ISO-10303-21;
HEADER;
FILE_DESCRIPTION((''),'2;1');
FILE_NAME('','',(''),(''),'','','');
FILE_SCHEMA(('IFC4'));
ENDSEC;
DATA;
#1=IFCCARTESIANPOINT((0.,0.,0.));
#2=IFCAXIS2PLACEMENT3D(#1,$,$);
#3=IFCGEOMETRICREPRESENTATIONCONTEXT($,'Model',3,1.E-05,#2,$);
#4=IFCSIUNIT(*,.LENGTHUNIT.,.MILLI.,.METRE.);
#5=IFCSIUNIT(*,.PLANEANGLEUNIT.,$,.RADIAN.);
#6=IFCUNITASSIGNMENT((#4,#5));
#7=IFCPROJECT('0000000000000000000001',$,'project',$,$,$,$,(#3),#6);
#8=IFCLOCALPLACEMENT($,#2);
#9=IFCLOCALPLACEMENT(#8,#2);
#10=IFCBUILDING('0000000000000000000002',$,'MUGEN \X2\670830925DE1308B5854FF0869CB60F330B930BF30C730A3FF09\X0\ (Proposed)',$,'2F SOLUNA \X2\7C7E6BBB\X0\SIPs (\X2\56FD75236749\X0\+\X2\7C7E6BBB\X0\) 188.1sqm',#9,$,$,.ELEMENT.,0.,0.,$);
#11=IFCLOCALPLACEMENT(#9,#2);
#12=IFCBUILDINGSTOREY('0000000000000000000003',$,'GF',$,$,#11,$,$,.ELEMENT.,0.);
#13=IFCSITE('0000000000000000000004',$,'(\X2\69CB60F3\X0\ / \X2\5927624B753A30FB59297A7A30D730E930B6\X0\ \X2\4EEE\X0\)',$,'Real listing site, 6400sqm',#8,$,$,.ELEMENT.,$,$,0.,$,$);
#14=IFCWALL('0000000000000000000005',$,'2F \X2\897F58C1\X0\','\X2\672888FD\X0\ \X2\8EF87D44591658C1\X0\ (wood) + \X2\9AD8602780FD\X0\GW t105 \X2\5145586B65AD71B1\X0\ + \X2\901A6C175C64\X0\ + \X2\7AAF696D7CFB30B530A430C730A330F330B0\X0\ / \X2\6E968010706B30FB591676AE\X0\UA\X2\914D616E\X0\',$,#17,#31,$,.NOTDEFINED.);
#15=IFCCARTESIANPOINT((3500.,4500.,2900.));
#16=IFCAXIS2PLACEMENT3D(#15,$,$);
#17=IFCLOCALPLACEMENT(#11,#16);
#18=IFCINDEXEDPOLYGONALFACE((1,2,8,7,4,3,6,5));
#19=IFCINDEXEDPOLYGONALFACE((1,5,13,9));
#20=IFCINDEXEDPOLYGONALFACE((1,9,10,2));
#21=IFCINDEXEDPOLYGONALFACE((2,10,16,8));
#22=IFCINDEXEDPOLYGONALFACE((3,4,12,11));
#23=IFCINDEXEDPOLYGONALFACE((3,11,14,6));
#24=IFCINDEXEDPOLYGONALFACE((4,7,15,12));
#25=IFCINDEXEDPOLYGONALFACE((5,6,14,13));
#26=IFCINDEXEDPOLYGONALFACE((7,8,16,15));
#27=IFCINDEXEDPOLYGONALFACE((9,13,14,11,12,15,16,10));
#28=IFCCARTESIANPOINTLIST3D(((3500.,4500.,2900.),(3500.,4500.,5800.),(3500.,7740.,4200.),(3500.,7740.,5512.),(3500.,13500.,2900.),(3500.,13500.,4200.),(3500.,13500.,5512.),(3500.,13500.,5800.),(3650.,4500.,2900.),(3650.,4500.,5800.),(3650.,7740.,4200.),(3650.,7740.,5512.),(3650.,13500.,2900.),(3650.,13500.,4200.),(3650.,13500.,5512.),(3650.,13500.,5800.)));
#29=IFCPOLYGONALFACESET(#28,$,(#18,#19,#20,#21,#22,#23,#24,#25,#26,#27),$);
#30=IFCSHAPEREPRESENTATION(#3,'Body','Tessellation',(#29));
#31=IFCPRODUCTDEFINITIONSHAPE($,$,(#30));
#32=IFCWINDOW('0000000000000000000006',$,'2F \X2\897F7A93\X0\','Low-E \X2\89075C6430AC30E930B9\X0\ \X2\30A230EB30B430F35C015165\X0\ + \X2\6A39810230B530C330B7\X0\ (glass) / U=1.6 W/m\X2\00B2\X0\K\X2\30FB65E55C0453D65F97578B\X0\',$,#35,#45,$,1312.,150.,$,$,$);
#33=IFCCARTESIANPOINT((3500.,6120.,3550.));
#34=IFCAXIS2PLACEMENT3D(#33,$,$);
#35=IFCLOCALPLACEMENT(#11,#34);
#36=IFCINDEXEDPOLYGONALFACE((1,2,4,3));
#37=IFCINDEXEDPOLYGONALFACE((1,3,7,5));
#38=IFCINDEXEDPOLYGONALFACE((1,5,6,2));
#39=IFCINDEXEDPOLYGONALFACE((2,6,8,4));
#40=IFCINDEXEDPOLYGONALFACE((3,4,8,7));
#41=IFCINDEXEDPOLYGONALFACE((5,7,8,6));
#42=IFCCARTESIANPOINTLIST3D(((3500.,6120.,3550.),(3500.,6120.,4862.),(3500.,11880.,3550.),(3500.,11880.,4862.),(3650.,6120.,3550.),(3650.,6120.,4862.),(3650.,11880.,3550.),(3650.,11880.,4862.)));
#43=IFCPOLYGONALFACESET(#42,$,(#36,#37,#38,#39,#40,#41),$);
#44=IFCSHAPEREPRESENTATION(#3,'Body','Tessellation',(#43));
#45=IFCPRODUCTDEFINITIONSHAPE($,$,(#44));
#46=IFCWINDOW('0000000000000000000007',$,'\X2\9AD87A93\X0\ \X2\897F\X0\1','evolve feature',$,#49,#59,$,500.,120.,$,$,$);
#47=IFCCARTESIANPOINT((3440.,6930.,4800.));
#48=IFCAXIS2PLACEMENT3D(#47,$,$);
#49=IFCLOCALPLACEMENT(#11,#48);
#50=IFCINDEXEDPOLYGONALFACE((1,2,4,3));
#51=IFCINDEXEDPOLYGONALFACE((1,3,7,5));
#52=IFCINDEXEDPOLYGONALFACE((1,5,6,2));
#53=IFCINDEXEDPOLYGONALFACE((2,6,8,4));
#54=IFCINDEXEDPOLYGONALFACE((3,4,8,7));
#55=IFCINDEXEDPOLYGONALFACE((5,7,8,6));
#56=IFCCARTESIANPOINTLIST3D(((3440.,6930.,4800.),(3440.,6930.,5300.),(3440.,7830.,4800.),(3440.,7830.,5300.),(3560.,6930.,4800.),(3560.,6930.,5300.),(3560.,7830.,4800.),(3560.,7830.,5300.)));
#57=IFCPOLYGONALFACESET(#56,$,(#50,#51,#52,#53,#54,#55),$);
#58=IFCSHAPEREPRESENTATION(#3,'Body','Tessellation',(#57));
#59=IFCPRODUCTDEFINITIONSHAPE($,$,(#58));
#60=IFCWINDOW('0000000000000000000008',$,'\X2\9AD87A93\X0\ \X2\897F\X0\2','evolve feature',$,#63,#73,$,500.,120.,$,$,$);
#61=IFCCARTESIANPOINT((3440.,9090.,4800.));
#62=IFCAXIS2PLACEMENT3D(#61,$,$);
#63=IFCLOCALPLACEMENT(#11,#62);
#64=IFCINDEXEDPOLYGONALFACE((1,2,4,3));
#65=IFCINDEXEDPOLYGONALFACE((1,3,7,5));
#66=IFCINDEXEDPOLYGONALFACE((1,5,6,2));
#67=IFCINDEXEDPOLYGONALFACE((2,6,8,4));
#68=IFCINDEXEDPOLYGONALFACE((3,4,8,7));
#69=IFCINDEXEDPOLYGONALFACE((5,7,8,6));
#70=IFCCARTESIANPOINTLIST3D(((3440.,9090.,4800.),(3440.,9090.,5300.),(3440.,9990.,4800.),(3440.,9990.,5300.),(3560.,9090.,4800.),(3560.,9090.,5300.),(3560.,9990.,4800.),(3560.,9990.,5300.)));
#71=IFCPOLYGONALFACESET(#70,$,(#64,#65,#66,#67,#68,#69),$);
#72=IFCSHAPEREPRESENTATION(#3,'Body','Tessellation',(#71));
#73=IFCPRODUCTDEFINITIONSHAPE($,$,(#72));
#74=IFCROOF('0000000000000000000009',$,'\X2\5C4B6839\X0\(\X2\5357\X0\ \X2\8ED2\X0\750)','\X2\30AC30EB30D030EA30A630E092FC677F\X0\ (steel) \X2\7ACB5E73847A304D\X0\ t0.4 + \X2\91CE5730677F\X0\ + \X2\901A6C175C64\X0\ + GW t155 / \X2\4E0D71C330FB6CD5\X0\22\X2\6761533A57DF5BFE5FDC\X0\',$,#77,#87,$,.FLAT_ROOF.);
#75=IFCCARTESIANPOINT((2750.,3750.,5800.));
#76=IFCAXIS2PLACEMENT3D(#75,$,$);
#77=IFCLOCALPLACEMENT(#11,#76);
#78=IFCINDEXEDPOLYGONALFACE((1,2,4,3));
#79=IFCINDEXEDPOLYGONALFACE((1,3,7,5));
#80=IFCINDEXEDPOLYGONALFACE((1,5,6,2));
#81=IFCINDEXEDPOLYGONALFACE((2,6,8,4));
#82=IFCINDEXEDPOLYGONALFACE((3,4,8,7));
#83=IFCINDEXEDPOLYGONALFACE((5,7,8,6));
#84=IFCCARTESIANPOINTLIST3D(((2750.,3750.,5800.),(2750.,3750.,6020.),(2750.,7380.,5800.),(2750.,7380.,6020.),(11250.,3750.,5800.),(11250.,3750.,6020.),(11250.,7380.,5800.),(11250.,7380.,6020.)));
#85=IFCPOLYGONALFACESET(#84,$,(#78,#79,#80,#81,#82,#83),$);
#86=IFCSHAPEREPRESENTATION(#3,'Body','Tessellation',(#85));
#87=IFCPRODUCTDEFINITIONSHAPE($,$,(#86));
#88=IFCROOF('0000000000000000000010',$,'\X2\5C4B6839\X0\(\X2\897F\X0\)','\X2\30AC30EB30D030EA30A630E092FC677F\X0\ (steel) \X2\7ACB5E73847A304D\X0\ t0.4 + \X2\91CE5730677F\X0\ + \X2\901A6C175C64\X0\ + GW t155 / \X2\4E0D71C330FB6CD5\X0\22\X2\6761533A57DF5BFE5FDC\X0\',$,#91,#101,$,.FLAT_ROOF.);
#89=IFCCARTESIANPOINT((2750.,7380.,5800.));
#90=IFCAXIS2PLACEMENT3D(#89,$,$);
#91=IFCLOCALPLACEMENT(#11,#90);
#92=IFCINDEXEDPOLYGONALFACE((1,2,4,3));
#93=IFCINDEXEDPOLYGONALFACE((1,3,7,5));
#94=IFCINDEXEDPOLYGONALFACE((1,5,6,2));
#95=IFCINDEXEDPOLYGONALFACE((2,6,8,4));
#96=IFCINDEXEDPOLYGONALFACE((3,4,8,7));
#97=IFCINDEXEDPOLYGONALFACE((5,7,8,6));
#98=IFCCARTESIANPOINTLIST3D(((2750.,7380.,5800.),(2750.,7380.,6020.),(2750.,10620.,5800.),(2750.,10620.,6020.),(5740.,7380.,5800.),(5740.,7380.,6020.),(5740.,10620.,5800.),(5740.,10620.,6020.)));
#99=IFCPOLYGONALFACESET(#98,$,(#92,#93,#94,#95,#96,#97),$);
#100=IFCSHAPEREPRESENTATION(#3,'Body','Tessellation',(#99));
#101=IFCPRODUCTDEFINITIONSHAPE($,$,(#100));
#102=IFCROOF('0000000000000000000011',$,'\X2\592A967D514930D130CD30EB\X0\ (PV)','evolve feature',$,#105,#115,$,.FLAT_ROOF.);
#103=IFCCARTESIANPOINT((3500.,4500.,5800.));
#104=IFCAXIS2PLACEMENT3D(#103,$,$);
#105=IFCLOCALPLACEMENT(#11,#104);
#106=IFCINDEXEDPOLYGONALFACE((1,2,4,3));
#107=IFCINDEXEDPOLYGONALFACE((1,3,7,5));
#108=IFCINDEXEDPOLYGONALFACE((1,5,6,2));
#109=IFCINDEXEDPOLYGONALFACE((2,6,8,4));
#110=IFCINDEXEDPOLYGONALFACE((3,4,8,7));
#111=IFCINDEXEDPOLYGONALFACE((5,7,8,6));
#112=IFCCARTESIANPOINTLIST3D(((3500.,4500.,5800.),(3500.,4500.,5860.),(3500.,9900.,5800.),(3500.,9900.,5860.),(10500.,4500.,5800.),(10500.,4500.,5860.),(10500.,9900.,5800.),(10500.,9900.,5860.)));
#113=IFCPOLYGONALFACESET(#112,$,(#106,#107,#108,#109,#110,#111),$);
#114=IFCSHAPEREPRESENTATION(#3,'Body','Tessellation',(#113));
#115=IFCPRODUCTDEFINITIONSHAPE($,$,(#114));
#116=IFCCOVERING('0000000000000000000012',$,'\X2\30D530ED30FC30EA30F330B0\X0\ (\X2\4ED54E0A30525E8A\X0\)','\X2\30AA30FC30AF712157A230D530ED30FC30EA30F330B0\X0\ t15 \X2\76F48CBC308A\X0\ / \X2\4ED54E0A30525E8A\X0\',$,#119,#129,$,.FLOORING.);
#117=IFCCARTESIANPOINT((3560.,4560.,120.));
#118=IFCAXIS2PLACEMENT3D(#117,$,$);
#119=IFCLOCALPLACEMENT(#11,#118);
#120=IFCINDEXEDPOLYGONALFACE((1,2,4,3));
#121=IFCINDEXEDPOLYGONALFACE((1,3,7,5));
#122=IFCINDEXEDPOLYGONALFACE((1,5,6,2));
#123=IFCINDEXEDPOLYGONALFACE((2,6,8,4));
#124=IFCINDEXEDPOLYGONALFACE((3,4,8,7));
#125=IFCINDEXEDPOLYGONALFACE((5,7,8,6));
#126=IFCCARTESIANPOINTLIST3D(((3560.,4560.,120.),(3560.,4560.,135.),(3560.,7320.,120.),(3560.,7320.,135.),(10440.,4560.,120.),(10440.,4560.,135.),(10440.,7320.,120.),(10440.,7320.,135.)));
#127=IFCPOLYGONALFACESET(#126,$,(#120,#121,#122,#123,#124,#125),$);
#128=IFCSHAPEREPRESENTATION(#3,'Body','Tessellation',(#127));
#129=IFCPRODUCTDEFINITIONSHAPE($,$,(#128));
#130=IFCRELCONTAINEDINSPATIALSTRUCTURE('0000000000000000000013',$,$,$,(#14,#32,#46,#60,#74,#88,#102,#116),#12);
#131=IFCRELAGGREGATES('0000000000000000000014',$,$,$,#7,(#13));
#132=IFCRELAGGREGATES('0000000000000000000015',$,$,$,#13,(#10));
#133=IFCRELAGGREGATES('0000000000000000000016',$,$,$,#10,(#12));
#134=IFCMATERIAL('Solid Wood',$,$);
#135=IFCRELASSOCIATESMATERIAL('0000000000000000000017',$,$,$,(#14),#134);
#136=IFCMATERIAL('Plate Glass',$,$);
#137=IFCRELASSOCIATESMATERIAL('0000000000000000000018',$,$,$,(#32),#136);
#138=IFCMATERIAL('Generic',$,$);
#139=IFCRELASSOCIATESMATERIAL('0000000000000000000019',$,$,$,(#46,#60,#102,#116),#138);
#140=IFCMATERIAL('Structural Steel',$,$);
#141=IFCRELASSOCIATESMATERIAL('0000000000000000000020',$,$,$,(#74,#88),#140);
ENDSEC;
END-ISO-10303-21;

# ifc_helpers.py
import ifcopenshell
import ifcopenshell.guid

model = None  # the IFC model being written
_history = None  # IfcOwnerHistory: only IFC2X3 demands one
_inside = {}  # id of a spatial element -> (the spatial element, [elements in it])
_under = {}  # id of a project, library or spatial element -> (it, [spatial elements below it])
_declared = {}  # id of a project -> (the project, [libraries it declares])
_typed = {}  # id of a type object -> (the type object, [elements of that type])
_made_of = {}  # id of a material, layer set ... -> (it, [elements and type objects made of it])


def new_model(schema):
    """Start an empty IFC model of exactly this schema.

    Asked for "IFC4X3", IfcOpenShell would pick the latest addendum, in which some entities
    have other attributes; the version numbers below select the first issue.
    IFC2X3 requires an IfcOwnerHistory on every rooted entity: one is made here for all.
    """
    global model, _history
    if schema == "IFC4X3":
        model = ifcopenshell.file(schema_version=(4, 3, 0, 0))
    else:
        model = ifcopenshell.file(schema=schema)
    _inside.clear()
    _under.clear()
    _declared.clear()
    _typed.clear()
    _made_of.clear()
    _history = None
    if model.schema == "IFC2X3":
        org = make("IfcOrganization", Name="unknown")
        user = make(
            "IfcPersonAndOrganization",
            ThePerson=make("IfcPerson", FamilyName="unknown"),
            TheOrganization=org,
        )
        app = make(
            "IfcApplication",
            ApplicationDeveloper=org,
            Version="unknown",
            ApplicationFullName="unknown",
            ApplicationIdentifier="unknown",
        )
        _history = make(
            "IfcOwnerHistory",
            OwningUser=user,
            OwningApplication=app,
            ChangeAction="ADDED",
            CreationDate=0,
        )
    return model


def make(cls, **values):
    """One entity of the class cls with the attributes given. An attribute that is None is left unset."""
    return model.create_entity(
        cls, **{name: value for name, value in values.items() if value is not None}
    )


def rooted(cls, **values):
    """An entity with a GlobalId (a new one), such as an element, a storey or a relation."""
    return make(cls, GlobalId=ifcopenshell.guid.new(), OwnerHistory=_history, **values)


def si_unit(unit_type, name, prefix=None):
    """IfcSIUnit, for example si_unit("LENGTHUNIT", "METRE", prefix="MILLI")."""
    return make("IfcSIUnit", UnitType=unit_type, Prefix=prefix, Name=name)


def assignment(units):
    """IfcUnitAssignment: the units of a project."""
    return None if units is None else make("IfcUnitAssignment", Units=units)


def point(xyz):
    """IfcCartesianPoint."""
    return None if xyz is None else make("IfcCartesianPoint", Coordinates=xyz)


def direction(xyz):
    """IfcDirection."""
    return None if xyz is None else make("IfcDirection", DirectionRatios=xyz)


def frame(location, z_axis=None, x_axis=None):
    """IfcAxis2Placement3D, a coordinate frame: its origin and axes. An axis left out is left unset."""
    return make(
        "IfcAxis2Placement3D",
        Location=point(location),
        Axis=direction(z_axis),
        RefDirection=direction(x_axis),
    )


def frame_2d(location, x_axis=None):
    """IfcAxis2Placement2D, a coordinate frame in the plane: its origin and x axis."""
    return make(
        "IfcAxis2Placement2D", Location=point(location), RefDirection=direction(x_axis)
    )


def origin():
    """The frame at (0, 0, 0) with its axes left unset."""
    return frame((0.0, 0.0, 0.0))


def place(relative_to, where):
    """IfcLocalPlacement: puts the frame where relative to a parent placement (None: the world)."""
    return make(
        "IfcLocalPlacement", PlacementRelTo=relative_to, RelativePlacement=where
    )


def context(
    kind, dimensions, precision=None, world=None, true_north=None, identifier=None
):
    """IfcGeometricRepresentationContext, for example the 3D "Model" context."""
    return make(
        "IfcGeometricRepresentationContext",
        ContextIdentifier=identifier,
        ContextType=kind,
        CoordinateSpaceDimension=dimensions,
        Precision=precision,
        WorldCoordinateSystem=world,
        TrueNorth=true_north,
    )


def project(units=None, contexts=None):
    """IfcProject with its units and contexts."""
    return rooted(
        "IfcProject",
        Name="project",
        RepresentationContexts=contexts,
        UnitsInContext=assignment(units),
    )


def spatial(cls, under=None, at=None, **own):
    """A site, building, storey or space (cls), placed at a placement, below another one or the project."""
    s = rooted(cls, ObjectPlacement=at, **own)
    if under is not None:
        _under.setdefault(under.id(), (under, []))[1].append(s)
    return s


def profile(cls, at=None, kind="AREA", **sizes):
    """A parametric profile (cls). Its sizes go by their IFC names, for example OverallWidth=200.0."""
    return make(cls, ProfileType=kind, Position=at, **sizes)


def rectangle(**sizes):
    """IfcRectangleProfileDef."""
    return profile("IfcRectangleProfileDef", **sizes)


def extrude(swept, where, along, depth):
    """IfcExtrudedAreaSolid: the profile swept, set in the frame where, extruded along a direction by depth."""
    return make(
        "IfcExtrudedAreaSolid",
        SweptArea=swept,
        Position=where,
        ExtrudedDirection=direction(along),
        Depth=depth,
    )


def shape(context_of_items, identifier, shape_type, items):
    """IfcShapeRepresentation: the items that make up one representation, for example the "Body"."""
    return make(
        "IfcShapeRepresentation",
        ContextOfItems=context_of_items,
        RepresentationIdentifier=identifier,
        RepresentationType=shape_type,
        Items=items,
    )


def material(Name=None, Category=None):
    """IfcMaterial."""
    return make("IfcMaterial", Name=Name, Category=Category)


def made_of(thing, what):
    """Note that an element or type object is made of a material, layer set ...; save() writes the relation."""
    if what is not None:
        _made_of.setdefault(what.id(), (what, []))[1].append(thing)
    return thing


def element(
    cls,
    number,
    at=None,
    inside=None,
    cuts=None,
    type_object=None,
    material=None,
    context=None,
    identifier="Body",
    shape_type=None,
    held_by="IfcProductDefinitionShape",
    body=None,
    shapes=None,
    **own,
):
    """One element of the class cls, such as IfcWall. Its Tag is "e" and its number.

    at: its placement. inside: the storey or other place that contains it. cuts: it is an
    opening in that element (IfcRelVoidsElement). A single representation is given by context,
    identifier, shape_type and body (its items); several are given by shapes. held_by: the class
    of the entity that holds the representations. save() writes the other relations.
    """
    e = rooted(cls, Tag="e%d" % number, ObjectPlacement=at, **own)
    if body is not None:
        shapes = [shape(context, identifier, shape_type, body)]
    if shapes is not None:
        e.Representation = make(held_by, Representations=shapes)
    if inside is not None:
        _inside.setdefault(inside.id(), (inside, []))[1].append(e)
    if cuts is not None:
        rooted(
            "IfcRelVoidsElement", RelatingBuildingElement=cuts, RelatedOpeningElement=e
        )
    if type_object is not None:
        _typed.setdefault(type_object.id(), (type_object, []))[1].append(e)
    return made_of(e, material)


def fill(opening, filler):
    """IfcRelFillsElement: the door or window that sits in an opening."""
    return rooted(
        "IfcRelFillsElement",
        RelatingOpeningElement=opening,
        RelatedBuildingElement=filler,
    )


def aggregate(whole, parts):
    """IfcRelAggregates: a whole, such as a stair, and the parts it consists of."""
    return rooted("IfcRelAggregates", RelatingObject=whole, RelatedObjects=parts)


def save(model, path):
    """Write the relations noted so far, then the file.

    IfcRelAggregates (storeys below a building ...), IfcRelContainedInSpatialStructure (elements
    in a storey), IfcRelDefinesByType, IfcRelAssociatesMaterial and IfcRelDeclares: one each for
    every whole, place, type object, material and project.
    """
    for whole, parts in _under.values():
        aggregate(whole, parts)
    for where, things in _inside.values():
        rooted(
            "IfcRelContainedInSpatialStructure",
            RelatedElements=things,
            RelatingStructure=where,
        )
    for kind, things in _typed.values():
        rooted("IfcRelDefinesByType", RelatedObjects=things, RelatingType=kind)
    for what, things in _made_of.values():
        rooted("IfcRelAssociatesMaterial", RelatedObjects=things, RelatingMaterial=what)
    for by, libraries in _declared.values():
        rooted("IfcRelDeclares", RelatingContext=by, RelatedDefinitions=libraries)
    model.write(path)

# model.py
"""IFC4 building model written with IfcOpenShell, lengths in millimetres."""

from ifc_helpers import new_model, si_unit, frame, frame_2d, origin, place, context, project, spatial, rectangle, extrude, material, element, fill, save


model = new_model("IFC4")

# Units and contexts
model_context = context("Model", 3, precision=1e-05, world=origin())
ifc_project = project(units=[si_unit("LENGTHUNIT", "METRE", prefix="MILLI"), si_unit("PLANEANGLEUNIT", "RADIAN")], contexts=[model_context])

# Site, building, storey
site_placement = place(None, origin())
site = spatial("IfcSite", under=ifc_project, at=site_placement, Name="(構想 / 大手町・天空プラザ 仮)", ObjectType="Real listing site, 6400sqm", CompositionType="ELEMENT", RefElevation=0.0)
building_placement = place(site_placement, origin())
building = spatial("IfcBuilding", under=site, at=building_placement, Name="MUGEN 月を巡る塔（構想スタディ） (Proposed)", ObjectType="2F SOLUNA 籾殻SIPs (国産杉+籾殻) 188.1sqm", CompositionType="ELEMENT", ElevationOfRefHeight=0.0, ElevationOfTerrain=0.0)
storey_placement = place(building_placement, origin())
storey = spatial("IfcBuildingStorey", under=building, at=storey_placement, Name="GF", CompositionType="ELEMENT", Elevation=0.0)

# Shared definitions
ifc_material_1 = material(Name="Solid Wood")
ifc_material_2 = material(Name="Generic")

# Shared definitions
ifc_material_3 = material(Name="Plate Glass")

# Wall, openings, windows
wall_1_placement = place(storey_placement, frame((3500.0, 4500.0, 2900.0)))
wall_1 = element("IfcWall", 1, at=wall_1_placement, inside=storey, material=ifc_material_1, Name="2F 西壁", Description="木製 軸組外壁 (wood) + 高性能GW t105 充填断熱 + 通気層 + 窯業系サイディング / 準耐火・外皮UA配慮", PredefinedType="NOTDEFINED", context=model_context, shape_type="SweptSolid", body=[
    extrude(rectangle(XDim=150.0, YDim=9000.0, at=frame_2d((75.0, 4500.0))), frame((3500.0, 4500.0, 2900.0)), (0.0, 0.0, 1.0), 2900.0),
])
opening_1_placement = place(storey_placement, frame((3500.0, 6120.0, 3550.0)))
opening_1 = element("IfcOpeningElement", 2, at=opening_1_placement, cuts=wall_1, PredefinedType="NOTDEFINED", context=model_context, shape_type="SweptSolid", body=[
    extrude(rectangle(XDim=150.0, YDim=5760.0, at=frame_2d((75.0, 2880.0))), frame((3500.0, 6120.0, 3550.0)), (0.0, 0.0, 1.0), 1312.0),
])
opening_2_placement = place(storey_placement, frame((3440.0, 6930.0, 4800.0)))
opening_2 = element("IfcOpeningElement", 3, at=opening_2_placement, cuts=wall_1, PredefinedType="NOTDEFINED", context=model_context, shape_type="SweptSolid", body=[
    extrude(rectangle(XDim=120.0, YDim=900.0, at=frame_2d((60.0, 450.0))), frame((3440.0, 6930.0, 4800.0)), (0.0, 0.0, 1.0), 500.0),
])
opening_3_placement = place(storey_placement, frame((3440.0, 9090.0, 4800.0)))
opening_3 = element("IfcOpeningElement", 4, at=opening_3_placement, cuts=wall_1, PredefinedType="NOTDEFINED", context=model_context, shape_type="SweptSolid", body=[
    extrude(rectangle(XDim=120.0, YDim=900.0, at=frame_2d((60.0, 450.0))), frame((3440.0, 9090.0, 4800.0)), (0.0, 0.0, 1.0), 500.0),
])
window_1_placement = place(storey_placement, frame((3500.0, 6120.0, 3550.0)))
window_1 = element("IfcWindow", 5, at=window_1_placement, inside=storey, material=ifc_material_3, Name="2F 西窓", Description="Low-E 複層ガラス アルゴン封入 + 樹脂サッシ (glass) / U=1.6 W/m²K・日射取得型", OverallHeight=1312.0, OverallWidth=150.0, context=model_context, shape_type="SweptSolid", body=[
    extrude(rectangle(XDim=150.0, YDim=5760.0, at=frame_2d((75.0, 2880.0))), frame((3500.0, 6120.0, 3550.0)), (0.0, 0.0, 1.0), 1312.0),
])
fill(opening_1, window_1)
window_2_placement = place(storey_placement, frame((3440.0, 6930.0, 4800.0)))
window_2 = element("IfcWindow", 6, at=window_2_placement, inside=storey, material=ifc_material_2, Name="高窓 西1", Description="evolve feature", OverallHeight=500.0, OverallWidth=120.0, context=model_context, shape_type="SweptSolid", body=[
    extrude(rectangle(XDim=120.0, YDim=900.0, at=frame_2d((60.0, 450.0))), frame((3440.0, 6930.0, 4800.0)), (0.0, 0.0, 1.0), 500.0),
])
fill(opening_2, window_2)
window_3_placement = place(storey_placement, frame((3440.0, 9090.0, 4800.0)))
window_3 = element("IfcWindow", 7, at=window_3_placement, inside=storey, material=ifc_material_2, Name="高窓 西2", Description="evolve feature", OverallHeight=500.0, OverallWidth=120.0, context=model_context, shape_type="SweptSolid", body=[
    extrude(rectangle(XDim=120.0, YDim=900.0, at=frame_2d((60.0, 450.0))), frame((3440.0, 9090.0, 4800.0)), (0.0, 0.0, 1.0), 500.0),
])
fill(opening_3, window_3)

# Roofs
ifc_material_4 = material(Name="Structural Steel")
roof_1_placement = place(storey_placement, frame((2750.0, 3750.0, 5800.0)))
element("IfcRoof", 8, at=roof_1_placement, inside=storey, material=ifc_material_4, Name="屋根(南 軒750)", Description="ガルバリウム鋼板 (steel) 立平葺き t0.4 + 野地板 + 通気層 + GW t155 / 不燃・法22条区域対応", PredefinedType="FLAT_ROOF", context=model_context, shape_type="SweptSolid", body=[
    extrude(rectangle(XDim=8500.0, YDim=3630.0, at=frame_2d((4250.0, 1815.0))), frame((2750.0, 3750.0, 5800.0)), (0.0, 0.0, 1.0), 220.0),
])
roof_2_placement = place(storey_placement, frame((2750.0, 7380.0, 5800.0)))
element("IfcRoof", 9, at=roof_2_placement, inside=storey, material=ifc_material_4, Name="屋根(西)", Description="ガルバリウム鋼板 (steel) 立平葺き t0.4 + 野地板 + 通気層 + GW t155 / 不燃・法22条区域対応", PredefinedType="FLAT_ROOF", context=model_context, shape_type="SweptSolid", body=[
    extrude(rectangle(XDim=2990.0, YDim=3240.0, at=frame_2d((1495.0, 1620.0))), frame((2750.0, 7380.0, 5800.0)), (0.0, 0.0, 1.0), 220.0),
])
roof_3_placement = place(storey_placement, frame((3500.0, 4500.0, 5800.0)))
element("IfcRoof", 10, at=roof_3_placement, inside=storey, material=ifc_material_2, Name="太陽光パネル (PV)", Description="evolve feature", PredefinedType="FLAT_ROOF", context=model_context, shape_type="SweptSolid", body=[
    extrude(rectangle(XDim=7000.0, YDim=5400.0, at=frame_2d((3500.0, 2700.0))), frame((3500.0, 4500.0, 5800.0)), (0.0, 0.0, 1.0), 60.0),
])

# Covering
covering_placement = place(storey_placement, frame((3560.0, 4560.0, 120.0)))
element("IfcCovering", 11, at=covering_placement, inside=storey, material=ifc_material_2, Name="フローリング (仕上げ床)", Description="オーク無垢フローリング t15 直貼り / 仕上げ床", PredefinedType="FLOORING", context=model_context, shape_type="SweptSolid", body=[
    extrude(rectangle(XDim=6880.0, YDim=2760.0, at=frame_2d((3440.0, 1380.0))), frame((3560.0, 4560.0, 120.0)), (0.0, 0.0, 1.0), 15.0),
])

save(model, "model.ifc")
